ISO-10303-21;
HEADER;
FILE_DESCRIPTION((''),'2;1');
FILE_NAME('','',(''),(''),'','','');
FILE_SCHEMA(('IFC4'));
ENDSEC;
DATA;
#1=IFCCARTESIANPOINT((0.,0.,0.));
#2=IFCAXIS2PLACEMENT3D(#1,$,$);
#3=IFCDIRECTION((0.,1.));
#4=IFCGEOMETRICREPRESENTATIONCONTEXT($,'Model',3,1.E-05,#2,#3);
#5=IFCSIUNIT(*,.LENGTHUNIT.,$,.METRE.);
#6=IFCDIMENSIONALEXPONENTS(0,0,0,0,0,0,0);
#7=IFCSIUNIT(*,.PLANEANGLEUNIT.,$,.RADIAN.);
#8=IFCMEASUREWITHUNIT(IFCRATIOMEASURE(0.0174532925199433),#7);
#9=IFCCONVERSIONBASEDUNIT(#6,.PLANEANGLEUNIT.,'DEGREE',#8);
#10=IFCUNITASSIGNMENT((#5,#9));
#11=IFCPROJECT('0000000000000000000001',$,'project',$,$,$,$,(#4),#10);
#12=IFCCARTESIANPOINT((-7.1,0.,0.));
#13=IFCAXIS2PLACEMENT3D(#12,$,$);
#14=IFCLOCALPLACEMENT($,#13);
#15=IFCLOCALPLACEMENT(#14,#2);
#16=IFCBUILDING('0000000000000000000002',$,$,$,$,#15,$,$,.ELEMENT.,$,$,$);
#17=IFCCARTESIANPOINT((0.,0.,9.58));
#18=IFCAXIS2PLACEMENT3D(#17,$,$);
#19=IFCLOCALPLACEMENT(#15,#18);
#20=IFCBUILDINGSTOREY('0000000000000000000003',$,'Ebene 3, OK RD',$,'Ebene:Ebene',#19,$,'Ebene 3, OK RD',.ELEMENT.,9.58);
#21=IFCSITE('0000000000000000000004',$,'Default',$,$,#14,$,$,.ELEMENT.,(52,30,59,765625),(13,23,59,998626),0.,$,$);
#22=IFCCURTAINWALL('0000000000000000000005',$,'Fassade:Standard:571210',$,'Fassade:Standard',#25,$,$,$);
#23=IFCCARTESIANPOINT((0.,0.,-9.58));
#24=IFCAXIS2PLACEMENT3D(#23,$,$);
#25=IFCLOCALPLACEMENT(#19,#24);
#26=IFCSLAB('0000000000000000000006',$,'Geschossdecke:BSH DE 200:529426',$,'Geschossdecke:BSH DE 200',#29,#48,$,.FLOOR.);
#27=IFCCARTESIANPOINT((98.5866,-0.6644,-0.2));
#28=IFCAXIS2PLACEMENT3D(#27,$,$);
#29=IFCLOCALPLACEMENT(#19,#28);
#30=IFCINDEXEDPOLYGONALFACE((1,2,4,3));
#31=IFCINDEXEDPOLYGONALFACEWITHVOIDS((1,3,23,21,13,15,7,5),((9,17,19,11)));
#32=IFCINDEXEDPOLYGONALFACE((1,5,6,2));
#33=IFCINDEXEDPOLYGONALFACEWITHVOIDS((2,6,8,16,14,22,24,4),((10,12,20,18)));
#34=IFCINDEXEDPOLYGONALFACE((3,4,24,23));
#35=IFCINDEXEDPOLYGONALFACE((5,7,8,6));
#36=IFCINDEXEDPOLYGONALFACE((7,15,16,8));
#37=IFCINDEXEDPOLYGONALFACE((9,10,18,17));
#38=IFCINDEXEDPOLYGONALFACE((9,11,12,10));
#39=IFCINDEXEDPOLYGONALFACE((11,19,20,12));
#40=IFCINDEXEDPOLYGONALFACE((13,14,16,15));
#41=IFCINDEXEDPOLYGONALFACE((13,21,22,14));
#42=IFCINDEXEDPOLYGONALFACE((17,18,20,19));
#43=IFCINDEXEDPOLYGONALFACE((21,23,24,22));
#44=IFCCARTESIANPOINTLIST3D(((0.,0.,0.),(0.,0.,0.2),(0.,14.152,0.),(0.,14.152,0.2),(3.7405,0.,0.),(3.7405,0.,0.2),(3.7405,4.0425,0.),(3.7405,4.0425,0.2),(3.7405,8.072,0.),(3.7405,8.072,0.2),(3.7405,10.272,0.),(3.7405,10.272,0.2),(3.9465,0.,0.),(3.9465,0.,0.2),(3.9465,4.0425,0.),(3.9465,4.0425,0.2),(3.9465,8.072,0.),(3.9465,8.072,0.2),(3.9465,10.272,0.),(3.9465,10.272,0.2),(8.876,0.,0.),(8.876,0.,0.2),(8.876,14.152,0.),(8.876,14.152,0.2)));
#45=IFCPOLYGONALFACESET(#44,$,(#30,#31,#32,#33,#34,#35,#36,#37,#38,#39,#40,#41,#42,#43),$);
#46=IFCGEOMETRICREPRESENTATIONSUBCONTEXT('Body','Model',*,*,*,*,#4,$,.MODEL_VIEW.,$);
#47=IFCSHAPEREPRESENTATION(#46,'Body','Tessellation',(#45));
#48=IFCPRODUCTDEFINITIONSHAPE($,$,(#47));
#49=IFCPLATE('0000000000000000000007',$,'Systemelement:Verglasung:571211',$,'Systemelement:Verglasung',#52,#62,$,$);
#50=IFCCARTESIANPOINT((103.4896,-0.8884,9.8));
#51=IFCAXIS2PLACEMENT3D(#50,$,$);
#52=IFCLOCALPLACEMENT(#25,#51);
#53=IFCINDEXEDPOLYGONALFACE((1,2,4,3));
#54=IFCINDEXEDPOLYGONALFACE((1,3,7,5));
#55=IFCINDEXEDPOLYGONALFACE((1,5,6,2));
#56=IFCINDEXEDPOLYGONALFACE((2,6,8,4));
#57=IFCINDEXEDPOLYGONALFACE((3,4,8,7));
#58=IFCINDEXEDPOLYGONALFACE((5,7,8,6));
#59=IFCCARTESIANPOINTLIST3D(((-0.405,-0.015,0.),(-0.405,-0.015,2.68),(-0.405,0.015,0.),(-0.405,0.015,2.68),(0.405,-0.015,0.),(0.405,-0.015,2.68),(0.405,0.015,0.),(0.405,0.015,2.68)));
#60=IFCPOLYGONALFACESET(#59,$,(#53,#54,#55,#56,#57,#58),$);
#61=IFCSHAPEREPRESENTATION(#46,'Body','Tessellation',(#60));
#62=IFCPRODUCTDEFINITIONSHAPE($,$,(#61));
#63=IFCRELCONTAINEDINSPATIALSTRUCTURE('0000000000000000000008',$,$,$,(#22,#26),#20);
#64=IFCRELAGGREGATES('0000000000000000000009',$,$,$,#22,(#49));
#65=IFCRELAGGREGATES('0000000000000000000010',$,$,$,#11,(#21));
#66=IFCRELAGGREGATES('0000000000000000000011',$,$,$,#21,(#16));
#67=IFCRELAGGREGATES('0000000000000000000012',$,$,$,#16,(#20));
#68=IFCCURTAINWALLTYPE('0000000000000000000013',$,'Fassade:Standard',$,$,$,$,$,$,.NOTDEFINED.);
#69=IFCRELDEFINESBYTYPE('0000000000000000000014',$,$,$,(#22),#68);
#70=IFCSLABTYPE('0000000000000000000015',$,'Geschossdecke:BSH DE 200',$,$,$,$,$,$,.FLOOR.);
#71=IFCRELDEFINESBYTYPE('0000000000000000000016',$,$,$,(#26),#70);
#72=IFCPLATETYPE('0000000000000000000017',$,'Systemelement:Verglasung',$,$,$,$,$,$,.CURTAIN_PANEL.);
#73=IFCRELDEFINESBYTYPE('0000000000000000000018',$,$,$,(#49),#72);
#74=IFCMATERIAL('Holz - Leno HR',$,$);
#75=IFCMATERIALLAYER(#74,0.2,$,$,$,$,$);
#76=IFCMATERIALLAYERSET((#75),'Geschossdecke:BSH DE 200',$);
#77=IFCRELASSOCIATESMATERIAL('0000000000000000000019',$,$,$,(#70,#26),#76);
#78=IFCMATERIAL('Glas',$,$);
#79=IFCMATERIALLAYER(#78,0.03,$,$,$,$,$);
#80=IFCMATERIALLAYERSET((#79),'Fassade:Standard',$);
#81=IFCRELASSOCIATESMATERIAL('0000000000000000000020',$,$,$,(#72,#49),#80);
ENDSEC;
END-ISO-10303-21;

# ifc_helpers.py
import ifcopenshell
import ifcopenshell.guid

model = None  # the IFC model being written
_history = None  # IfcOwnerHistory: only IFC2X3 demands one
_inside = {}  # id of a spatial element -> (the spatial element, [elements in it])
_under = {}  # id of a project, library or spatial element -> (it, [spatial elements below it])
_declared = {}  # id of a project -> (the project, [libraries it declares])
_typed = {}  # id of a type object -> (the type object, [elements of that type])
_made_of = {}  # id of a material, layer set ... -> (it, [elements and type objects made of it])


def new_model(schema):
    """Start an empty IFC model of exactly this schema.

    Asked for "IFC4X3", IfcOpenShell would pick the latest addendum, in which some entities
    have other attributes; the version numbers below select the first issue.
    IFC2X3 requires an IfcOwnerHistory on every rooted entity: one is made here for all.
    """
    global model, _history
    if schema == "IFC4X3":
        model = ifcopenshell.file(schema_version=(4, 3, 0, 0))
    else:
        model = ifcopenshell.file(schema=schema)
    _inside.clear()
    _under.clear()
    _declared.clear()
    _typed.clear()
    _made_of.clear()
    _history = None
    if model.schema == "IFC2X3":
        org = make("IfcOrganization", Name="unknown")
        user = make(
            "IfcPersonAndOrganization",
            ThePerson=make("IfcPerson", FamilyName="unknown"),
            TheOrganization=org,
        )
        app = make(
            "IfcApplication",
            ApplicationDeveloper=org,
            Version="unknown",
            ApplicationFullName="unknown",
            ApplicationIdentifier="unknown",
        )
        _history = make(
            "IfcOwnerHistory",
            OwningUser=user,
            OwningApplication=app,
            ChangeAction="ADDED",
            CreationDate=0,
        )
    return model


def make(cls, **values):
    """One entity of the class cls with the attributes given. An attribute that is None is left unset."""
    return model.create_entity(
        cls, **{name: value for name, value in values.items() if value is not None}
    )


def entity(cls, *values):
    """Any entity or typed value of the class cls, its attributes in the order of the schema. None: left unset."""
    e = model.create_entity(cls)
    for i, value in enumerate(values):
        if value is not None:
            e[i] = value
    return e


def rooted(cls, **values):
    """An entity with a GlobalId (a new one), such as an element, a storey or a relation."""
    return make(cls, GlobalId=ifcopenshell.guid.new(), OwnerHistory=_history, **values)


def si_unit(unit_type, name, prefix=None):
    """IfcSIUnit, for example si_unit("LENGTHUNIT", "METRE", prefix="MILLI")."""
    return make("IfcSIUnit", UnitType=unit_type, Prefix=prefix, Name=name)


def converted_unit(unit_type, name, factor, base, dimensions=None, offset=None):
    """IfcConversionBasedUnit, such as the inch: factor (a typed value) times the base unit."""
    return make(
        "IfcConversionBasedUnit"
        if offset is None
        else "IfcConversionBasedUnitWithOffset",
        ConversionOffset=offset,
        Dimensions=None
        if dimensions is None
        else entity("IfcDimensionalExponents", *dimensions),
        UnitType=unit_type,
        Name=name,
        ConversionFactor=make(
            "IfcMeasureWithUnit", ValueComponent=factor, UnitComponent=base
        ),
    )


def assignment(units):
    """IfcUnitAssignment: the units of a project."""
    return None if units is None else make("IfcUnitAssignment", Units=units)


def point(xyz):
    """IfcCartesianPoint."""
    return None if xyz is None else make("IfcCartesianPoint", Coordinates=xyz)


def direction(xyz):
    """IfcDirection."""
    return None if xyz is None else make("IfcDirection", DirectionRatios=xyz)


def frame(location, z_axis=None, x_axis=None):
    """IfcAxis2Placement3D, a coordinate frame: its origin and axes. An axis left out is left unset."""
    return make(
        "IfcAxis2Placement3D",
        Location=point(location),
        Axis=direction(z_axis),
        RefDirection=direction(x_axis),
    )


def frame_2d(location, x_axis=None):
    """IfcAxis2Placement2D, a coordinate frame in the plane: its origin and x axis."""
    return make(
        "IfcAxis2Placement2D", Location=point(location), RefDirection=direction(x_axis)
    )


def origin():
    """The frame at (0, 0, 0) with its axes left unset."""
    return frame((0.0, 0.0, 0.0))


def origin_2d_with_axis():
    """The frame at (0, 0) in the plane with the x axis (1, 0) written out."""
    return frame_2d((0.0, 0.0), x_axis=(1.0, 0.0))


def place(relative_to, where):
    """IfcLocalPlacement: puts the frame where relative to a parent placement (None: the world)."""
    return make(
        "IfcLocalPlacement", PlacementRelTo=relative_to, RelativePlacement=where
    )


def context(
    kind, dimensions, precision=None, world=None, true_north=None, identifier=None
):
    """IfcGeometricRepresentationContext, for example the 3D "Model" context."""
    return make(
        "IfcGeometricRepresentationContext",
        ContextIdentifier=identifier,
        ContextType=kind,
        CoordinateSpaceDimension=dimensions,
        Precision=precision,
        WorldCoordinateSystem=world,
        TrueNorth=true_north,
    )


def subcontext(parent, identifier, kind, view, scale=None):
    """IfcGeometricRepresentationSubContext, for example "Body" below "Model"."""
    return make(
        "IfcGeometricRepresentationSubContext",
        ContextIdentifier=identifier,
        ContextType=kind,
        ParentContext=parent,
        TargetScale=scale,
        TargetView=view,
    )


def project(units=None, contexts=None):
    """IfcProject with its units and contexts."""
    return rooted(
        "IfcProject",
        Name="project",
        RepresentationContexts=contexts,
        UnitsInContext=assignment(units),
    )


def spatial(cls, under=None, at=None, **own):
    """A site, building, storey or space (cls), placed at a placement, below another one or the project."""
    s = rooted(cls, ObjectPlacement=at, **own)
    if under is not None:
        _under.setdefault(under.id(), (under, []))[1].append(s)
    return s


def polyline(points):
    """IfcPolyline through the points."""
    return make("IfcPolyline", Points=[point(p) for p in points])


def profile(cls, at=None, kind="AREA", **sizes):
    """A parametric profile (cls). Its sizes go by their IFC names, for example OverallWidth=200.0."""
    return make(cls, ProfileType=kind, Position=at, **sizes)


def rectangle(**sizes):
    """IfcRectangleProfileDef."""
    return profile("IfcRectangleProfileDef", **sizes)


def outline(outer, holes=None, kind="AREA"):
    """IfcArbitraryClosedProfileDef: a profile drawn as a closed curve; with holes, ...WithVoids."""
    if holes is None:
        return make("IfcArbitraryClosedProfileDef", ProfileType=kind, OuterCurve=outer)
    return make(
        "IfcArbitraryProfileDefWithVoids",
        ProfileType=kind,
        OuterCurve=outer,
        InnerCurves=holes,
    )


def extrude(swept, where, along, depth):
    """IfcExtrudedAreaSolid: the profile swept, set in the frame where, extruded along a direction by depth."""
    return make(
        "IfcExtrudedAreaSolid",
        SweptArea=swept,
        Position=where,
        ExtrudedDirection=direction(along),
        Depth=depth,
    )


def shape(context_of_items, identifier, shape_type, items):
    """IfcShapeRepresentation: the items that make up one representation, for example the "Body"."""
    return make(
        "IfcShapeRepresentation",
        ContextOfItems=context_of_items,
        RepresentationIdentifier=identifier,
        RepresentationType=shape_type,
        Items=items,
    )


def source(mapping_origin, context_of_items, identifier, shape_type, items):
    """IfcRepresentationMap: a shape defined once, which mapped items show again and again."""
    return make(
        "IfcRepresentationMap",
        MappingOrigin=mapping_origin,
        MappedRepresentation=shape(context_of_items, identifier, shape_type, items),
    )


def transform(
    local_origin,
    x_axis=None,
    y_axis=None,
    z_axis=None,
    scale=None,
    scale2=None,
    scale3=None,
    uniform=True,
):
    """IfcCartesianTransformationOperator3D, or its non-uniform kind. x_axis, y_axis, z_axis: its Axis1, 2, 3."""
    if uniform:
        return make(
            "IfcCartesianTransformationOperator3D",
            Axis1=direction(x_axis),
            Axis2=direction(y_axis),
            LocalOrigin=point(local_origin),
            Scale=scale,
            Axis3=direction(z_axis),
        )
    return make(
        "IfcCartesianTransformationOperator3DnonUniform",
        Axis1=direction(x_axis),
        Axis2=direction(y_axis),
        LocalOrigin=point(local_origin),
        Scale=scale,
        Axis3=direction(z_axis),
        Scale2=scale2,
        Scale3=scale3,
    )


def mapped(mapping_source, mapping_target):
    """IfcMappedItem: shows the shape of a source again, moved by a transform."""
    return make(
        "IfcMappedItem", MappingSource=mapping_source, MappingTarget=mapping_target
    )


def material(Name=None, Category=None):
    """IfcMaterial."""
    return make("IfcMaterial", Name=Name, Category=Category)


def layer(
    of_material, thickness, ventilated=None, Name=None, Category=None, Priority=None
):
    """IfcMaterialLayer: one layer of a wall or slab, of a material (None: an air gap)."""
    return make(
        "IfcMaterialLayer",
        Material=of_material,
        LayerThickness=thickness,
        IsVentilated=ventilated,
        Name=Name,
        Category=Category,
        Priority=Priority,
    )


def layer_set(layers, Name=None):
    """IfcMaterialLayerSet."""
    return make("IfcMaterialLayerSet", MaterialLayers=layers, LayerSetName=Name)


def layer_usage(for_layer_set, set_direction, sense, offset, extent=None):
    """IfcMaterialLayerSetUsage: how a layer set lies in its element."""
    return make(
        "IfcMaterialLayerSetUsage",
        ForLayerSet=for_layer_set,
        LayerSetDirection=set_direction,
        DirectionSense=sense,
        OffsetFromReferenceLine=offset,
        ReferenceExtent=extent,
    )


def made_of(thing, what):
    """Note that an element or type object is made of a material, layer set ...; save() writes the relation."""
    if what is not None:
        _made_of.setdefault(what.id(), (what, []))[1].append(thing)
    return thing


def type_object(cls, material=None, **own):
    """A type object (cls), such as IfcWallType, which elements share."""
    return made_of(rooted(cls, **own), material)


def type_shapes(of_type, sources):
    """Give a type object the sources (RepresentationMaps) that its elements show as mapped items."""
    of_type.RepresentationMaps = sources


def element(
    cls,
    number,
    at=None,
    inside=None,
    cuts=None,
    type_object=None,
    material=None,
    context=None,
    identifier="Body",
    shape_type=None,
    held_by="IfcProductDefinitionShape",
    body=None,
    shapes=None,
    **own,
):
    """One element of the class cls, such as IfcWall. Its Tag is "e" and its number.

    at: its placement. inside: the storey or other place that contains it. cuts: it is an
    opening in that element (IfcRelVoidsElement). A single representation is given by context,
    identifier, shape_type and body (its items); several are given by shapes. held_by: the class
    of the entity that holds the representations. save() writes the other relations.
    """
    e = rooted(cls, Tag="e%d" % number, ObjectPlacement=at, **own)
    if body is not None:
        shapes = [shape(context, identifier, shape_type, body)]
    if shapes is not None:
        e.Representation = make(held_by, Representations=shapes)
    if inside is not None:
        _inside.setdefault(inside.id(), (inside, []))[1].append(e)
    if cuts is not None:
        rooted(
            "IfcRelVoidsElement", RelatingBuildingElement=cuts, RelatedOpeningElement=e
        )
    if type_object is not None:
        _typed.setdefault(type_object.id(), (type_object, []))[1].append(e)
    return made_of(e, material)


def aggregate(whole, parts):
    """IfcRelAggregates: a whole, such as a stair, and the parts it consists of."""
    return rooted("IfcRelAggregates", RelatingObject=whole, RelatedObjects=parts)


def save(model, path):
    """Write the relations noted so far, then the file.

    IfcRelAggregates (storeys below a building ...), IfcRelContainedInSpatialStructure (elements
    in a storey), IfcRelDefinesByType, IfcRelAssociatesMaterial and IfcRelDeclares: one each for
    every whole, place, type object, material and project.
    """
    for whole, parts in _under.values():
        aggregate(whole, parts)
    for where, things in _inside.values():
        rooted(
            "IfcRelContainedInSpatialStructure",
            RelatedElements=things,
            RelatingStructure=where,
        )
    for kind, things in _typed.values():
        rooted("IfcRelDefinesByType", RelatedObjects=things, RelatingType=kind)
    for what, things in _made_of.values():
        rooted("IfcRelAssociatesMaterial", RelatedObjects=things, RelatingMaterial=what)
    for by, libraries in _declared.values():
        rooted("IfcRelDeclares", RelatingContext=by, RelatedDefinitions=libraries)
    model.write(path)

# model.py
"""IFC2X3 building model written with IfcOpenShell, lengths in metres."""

from ifc_helpers import new_model, entity, si_unit, converted_unit, direction, frame, origin, origin_2d_with_axis, place, context, subcontext, project, spatial, polyline, rectangle, outline, extrude, source, transform, mapped, material, layer, layer_set, layer_usage, type_object, type_shapes, element, aggregate, save


model = new_model("IFC2X3")

# Units and contexts
model_context = context("Model", 3, precision=1e-05, world=origin(), true_north=direction((0.0, 1.0)))
body_context = subcontext(model_context, "Body", "Model", "MODEL_VIEW")
ifc_project = project(units=[si_unit("LENGTHUNIT", "METRE"), converted_unit("PLANEANGLEUNIT", "DEGREE", entity("IfcRatioMeasure", 0.0174532925199433), si_unit("PLANEANGLEUNIT", "RADIAN"), dimensions=[0, 0, 0, 0, 0, 0, 0])], contexts=[model_context])

# Site, building, storey
site_placement = place(None, frame((-7.1, 0.0, 0.0)))
site = spatial("IfcSite", under=ifc_project, at=site_placement, Name="Default", CompositionType="ELEMENT", RefLatitude=(52, 30, 59, 765625), RefLongitude=(13, 23, 59, 998626), RefElevation=0.0)
building_placement = place(site_placement, origin())
building = spatial("IfcBuilding", under=site, at=building_placement, CompositionType="ELEMENT")
storey_placement = place(building_placement, frame((0.0, 0.0, 9.58)))
storey = spatial("IfcBuildingStorey", under=building, at=storey_placement, Name="Ebene 3, OK RD", ObjectType="Ebene:Ebene", LongName="Ebene 3, OK RD", CompositionType="ELEMENT", Elevation=9.58)

# Curtain wall
curtain_wall_type = type_object("IfcCurtainWallType", Name="Fassade:Standard", PredefinedType="NOTDEFINED")
curtain_wall_1_placement = place(storey_placement, frame((0.0, 0.0, -9.58)))
curtain_wall_1 = element("IfcCurtainWall", 1, at=curtain_wall_1_placement, inside=storey, type_object=curtain_wall_type, Name="Fassade:Standard:571210", ObjectType="Fassade:Standard")

# Slab, opening
ifc_material_1 = material(Name="Holz - Leno HR")
ifc_layer_1 = layer(ifc_material_1, 0.2)
ifc_layer_set_1 = layer_set([ifc_layer_1], Name="Geschossdecke:BSH DE 200")
ifc_layer_usage_1 = layer_usage(ifc_layer_set_1, "AXIS3", "POSITIVE", 0.0)
slab_type_1 = type_object("IfcSlabType", Name="Geschossdecke:BSH DE 200", PredefinedType="FLOOR", material=ifc_layer_set_1)
slab_placement = place(storey_placement, frame((98.5866, -0.6644, -0.2)))
slab = element("IfcSlab", 2, at=slab_placement, inside=storey, type_object=slab_type_1, material=ifc_layer_usage_1, Name="Geschossdecke:BSH DE 200:529426", ObjectType="Geschossdecke:BSH DE 200", PredefinedType="FLOOR", context=body_context, shape_type="SweptSolid", body=[
    extrude(outline(polyline([(-4.438, 7.076), (-4.438, -7.076), (0.4915, -7.076), (0.4915, -3.0335), (0.6975, -3.0335), (0.6975, -7.076), (4.438, -7.076), (4.438, 7.076), (-4.438, 7.076)])), frame((4.438, 7.076, 0.2), z_axis=(0.0, 0.0, -1.0), x_axis=(-1.0, 0.0, 0.0)), (0.0, 0.0, 1.0), 0.2),
])
opening_1_placement = place(slab_placement, frame((3.8435, 9.172, 0.2)))
element("IfcOpeningElement", 3, at=opening_1_placement, cuts=slab, ObjectType="Opening", context=body_context, shape_type="SweptSolid", body=[
    extrude(rectangle(XDim=0.206, YDim=2.2, at=origin_2d_with_axis()), frame((0.0, 0.0, 0.0), z_axis=(0.0, 0.0, -1.0), x_axis=(1.0, 0.0, 0.0)), (0.0, 0.0, 1.0), 0.2),
])

# Plate
ifc_material_2 = material(Name="Glas")
ifc_layer_2 = layer(ifc_material_2, 0.03)
ifc_layer_set_2 = layer_set([ifc_layer_2], Name="Fassade:Standard")
ifc_layer_usage_2 = layer_usage(ifc_layer_set_2, "AXIS3", "POSITIVE", 0.0)
plate_type = type_object("IfcPlateType", Name="Systemelement:Verglasung", PredefinedType="CURTAIN_PANEL", material=ifc_layer_set_2)
shared_shape_1 = source(origin(), body_context, "Body", "SweptSolid", [
    extrude(rectangle(XDim=0.03, YDim=0.81, at=origin_2d_with_axis()), frame((0.0, 0.0, 0.0), z_axis=(0.0, 0.0, 1.0), x_axis=(0.0, 1.0, 0.0)), (0.0, 0.0, 1.0), 2.68),
])
type_shapes(plate_type, [shared_shape_1])
plate_placement = place(curtain_wall_1_placement, frame((103.4896, -0.8884, 9.8)))
plate = element("IfcPlate", 4, at=plate_placement, type_object=plate_type, material=ifc_layer_usage_2, Name="Systemelement:Verglasung:571211", ObjectType="Systemelement:Verglasung", context=body_context, shape_type="MappedRepresentation", body=[
    mapped(shared_shape_1, transform((0.0, 0.0, 0.0), scale=1.0)),
])
aggregate(curtain_wall_1, [plate])

save(model, "model.ifc")
